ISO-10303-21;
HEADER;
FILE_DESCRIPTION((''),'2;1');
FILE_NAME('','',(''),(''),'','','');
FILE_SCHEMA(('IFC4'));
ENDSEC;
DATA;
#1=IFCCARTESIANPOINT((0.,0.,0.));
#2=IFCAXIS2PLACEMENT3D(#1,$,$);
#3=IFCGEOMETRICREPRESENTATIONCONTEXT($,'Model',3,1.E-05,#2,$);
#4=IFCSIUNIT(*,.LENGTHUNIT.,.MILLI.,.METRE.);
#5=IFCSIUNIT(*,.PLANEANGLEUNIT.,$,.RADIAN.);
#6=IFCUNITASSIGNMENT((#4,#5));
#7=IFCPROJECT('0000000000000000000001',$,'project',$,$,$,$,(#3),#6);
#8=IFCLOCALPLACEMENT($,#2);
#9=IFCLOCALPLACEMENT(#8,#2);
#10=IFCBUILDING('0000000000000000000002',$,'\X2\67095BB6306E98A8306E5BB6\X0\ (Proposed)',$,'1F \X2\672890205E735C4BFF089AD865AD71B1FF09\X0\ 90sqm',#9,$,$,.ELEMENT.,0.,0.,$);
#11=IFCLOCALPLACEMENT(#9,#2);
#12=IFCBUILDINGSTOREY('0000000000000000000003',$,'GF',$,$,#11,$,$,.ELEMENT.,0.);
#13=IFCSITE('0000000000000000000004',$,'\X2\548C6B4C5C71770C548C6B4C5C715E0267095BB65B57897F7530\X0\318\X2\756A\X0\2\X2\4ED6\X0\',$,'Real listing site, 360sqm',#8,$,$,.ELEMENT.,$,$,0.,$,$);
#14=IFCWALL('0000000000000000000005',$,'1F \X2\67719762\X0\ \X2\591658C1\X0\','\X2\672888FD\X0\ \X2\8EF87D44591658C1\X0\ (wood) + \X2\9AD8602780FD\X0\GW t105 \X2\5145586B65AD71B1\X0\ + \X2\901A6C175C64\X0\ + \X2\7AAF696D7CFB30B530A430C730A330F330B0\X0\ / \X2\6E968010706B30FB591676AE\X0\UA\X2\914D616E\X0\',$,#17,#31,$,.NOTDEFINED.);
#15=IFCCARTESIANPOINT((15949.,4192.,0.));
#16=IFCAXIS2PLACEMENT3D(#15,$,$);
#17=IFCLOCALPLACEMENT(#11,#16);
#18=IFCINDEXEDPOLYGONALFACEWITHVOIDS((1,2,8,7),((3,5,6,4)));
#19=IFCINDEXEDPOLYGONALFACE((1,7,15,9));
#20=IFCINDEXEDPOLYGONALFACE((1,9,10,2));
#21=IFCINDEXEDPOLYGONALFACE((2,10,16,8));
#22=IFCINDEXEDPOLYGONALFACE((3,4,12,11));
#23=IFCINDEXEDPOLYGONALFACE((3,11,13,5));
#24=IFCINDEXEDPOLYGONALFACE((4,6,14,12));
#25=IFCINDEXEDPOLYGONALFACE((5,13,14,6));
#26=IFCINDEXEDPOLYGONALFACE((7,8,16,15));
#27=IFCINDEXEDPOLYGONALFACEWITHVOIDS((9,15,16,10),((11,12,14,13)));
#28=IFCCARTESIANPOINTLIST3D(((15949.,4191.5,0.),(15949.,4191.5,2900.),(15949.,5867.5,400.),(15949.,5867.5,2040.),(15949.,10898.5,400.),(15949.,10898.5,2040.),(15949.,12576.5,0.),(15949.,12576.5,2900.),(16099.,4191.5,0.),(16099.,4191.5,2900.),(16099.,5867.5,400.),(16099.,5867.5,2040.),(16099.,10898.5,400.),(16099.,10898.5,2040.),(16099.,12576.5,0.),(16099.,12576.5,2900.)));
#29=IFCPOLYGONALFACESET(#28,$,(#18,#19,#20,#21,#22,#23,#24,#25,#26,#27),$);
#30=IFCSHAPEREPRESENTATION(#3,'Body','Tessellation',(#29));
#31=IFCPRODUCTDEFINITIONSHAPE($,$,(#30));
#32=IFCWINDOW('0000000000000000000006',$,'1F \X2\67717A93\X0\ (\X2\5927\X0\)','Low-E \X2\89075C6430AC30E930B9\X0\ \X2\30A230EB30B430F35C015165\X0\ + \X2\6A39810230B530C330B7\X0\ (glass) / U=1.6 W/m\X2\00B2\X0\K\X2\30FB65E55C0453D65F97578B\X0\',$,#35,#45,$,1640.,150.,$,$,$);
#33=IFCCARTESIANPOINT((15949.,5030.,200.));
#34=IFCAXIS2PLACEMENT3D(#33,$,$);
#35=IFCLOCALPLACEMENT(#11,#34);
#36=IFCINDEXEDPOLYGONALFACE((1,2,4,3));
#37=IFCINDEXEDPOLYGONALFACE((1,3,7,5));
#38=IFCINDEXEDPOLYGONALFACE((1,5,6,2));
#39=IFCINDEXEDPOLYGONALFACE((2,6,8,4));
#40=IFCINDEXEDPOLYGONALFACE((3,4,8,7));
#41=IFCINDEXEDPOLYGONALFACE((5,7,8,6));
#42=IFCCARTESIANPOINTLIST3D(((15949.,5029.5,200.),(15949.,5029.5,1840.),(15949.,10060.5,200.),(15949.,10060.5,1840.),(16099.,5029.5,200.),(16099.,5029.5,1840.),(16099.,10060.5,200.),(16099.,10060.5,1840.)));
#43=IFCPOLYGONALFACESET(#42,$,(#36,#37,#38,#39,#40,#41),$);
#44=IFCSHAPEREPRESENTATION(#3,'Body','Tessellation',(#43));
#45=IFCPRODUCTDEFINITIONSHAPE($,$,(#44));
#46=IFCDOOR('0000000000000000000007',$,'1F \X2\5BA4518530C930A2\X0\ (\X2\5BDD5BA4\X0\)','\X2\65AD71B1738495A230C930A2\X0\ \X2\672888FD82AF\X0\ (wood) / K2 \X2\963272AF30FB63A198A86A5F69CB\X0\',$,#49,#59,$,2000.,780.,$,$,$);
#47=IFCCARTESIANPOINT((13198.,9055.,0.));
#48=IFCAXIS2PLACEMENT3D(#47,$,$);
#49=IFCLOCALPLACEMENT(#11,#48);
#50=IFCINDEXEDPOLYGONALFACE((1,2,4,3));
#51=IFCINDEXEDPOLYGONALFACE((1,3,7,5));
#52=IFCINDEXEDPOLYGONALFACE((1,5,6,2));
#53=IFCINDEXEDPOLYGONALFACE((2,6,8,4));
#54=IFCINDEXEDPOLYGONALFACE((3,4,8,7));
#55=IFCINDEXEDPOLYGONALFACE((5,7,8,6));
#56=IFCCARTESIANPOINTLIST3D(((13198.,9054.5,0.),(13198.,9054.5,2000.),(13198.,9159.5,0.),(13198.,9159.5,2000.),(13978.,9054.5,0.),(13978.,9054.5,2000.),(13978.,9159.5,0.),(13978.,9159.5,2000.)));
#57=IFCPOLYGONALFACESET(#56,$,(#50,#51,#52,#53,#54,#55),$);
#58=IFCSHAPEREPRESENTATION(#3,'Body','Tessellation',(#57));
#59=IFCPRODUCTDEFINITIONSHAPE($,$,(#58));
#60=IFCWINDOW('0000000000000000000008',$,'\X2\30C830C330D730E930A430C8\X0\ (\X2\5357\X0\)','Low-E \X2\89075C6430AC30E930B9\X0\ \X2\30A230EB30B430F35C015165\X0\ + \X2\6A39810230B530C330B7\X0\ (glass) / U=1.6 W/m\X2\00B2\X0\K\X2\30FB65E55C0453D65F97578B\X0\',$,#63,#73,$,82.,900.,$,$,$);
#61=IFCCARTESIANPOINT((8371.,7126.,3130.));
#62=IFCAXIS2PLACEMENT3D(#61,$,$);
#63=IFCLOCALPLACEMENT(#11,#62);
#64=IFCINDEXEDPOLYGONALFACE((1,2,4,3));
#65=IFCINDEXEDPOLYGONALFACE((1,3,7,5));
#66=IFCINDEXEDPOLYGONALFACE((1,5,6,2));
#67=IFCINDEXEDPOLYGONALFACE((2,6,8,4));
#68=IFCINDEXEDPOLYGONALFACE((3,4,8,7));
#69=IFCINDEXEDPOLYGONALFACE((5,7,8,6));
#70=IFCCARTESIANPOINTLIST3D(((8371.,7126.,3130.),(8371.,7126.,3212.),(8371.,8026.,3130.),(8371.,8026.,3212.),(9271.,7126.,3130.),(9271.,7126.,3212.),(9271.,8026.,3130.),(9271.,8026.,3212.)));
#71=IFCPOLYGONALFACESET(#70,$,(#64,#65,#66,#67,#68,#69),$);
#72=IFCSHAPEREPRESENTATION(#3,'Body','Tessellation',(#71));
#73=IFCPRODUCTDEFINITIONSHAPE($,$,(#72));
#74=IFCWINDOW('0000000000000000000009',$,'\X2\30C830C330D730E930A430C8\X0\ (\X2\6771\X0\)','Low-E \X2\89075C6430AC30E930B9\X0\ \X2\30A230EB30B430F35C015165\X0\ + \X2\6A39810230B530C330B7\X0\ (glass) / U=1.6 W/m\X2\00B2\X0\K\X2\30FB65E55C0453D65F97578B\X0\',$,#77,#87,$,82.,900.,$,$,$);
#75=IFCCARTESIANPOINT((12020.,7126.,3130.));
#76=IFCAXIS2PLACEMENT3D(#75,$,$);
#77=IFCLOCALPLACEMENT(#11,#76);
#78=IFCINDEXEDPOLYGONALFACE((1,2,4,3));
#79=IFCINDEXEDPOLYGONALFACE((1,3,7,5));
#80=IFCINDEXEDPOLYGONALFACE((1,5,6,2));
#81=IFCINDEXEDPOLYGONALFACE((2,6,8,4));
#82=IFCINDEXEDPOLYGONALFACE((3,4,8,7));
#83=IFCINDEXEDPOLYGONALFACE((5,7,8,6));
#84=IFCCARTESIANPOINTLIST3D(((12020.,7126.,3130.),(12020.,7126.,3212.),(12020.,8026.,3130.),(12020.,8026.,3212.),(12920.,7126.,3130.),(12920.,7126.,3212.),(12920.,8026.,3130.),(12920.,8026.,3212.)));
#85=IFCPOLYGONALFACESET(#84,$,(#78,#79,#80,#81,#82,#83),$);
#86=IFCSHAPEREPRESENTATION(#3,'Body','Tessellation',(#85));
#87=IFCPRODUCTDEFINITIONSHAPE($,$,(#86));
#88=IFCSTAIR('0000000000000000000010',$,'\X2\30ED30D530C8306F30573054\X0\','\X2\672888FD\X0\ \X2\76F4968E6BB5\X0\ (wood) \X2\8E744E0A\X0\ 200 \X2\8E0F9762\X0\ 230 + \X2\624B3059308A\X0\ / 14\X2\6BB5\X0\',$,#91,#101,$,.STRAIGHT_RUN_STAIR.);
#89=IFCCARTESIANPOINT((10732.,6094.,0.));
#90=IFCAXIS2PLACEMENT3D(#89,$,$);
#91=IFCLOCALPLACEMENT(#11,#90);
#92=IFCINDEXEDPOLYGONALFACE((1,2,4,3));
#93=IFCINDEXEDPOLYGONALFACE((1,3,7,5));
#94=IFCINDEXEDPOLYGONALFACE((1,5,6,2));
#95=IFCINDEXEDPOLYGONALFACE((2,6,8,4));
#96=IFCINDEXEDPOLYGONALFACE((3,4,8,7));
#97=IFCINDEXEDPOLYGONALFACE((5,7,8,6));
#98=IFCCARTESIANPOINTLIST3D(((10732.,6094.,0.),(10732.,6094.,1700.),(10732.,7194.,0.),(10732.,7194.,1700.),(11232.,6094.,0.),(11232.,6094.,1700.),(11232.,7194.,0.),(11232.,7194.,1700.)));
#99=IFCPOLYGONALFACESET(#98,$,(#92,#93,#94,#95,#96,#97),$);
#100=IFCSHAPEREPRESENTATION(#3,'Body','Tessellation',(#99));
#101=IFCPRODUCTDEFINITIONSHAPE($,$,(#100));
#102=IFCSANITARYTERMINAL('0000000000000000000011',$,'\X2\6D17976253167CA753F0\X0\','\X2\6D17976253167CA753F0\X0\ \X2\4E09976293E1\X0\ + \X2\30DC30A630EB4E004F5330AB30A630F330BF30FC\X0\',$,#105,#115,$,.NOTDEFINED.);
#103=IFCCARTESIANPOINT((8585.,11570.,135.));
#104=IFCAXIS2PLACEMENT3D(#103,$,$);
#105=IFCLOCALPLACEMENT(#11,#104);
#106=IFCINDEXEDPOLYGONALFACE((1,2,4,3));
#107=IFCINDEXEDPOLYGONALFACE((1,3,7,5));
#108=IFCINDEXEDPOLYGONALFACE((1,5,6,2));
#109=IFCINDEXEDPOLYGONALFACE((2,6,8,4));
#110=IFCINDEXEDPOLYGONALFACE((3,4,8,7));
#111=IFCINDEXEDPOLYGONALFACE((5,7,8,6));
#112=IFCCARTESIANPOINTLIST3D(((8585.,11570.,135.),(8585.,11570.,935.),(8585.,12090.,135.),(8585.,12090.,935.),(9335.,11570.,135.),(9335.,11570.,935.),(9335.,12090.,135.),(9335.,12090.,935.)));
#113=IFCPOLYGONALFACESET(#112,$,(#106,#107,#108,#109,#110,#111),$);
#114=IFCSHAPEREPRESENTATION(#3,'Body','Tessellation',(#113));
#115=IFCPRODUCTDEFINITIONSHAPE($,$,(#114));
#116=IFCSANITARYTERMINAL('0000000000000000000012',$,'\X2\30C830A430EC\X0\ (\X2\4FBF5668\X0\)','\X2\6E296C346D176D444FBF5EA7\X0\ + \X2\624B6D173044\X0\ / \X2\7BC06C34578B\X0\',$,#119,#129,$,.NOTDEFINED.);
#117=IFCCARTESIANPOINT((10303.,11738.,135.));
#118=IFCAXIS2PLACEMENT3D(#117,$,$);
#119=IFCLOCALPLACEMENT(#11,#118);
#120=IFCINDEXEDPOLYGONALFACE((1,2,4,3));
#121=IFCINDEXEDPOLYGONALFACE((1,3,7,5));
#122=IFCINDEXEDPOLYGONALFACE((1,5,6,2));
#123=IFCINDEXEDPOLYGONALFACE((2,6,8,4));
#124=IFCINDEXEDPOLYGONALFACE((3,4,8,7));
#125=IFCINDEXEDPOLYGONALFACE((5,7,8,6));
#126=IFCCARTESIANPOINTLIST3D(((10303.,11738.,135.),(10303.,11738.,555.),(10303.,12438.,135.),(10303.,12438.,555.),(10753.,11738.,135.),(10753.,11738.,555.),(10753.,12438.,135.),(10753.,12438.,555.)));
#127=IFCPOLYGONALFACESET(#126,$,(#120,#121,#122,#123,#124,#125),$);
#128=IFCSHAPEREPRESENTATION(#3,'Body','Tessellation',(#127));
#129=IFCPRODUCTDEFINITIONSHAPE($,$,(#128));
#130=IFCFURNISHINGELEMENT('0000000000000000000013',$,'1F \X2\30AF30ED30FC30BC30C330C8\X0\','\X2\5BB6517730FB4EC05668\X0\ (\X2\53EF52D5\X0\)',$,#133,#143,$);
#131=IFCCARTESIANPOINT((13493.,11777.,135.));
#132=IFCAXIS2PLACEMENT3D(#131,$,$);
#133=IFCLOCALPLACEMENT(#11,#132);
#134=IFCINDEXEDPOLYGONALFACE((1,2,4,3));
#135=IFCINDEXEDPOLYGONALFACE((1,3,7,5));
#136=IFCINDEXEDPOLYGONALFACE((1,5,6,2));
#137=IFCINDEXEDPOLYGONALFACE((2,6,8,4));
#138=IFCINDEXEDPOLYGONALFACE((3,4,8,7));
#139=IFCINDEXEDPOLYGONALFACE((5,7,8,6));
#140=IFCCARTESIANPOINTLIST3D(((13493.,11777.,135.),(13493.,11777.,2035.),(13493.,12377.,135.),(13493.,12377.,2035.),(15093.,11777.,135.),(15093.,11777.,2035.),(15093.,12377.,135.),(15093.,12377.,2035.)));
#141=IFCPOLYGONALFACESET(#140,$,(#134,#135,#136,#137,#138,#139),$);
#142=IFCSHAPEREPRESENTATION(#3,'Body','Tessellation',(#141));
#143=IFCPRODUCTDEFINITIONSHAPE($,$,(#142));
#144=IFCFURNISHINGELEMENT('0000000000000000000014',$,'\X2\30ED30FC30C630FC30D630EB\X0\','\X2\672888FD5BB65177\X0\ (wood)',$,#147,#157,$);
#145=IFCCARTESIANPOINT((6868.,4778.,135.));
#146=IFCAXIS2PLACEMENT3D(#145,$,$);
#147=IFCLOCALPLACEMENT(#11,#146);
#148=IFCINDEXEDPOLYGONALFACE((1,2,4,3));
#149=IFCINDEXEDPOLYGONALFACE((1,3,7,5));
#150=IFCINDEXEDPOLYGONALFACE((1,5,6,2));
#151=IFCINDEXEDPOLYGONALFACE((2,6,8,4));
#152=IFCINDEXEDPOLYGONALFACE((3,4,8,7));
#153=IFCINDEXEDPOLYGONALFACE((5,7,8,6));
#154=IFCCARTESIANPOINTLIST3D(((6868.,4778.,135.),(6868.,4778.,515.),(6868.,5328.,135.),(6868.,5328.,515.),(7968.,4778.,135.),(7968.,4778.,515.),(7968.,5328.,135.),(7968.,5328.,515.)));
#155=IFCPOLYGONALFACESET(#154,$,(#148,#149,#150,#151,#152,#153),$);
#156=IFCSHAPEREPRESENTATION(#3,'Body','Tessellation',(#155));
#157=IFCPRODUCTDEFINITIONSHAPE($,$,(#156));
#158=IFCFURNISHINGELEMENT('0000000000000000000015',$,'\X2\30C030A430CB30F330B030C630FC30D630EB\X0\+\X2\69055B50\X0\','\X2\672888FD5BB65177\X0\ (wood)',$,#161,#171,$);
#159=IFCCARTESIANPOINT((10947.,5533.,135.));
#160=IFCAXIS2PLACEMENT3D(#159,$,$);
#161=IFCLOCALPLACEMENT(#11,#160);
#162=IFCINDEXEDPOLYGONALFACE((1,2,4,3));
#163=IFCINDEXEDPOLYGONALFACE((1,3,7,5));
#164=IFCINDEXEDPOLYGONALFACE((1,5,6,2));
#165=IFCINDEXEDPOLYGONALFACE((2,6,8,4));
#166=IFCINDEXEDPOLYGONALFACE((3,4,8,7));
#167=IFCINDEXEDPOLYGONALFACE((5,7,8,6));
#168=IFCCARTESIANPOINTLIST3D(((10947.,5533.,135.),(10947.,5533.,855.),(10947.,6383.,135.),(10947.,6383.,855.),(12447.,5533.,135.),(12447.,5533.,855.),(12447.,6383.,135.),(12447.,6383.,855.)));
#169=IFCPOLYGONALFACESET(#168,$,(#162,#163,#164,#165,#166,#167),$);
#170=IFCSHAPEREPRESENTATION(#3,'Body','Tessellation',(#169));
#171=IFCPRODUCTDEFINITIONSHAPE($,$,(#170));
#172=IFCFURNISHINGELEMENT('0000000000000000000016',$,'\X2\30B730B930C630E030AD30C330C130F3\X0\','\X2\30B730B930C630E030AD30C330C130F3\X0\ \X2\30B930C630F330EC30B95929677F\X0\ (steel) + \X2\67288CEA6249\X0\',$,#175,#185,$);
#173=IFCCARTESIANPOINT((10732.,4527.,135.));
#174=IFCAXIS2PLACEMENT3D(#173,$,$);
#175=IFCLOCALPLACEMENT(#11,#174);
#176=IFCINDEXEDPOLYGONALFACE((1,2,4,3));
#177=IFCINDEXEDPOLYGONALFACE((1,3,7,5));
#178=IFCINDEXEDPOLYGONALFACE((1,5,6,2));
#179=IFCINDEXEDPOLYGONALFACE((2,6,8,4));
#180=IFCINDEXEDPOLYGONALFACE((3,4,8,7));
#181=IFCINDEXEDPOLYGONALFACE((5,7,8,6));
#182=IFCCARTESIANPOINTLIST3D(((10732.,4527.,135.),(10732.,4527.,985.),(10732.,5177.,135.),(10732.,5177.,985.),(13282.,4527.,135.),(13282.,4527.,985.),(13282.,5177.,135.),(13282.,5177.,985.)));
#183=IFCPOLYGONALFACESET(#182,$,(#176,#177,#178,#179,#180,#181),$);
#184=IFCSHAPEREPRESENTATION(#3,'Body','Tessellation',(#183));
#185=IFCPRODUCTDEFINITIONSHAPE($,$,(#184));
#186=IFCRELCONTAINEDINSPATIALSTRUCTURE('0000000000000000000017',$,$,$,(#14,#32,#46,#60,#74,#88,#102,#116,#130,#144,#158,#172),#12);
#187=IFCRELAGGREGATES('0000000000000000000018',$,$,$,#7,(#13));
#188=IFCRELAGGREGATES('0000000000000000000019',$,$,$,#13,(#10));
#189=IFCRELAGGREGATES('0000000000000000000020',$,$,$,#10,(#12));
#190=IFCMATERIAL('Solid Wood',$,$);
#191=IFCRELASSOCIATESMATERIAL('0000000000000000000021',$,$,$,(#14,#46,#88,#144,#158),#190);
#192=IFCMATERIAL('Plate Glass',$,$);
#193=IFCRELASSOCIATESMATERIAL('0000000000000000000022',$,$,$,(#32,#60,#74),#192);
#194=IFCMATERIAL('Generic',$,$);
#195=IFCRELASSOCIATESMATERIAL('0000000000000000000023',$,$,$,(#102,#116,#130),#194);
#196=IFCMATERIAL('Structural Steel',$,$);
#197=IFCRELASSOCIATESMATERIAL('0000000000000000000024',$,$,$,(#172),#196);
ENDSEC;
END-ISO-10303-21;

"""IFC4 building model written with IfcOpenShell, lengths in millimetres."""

from ifc_helpers import new_model, si_unit, frame, frame_2d, origin, place, context, project, spatial, rectangle, extrude, material, element, fill, save


model = new_model("IFC4")

# Units and contexts
model_context = context("Model", 3, precision=1e-05, world=origin())
ifc_project = project(units=[si_unit("LENGTHUNIT", "METRE", prefix="MILLI"), si_unit("PLANEANGLEUNIT", "RADIAN")], contexts=[model_context])

# Site, building, storey
site_placement = place(None, origin())
site = spatial("IfcSite", under=ifc_project, at=site_placement, Name="和歌山県和歌山市有家字西田318番2他", ObjectType="Real listing site, 360sqm", CompositionType="ELEMENT", RefElevation=0.0)
building_placement = place(site_placement, origin())
building = spatial("IfcBuilding", under=site, at=building_placement, Name="有家の風の家 (Proposed)", ObjectType="1F 木造平屋（高断熱） 90sqm", CompositionType="ELEMENT", ElevationOfRefHeight=0.0, ElevationOfTerrain=0.0)
storey_placement = place(building_placement, origin())
storey = spatial("IfcBuildingStorey", under=building, at=storey_placement, Name="GF", CompositionType="ELEMENT", Elevation=0.0)

# Wall, opening, window
ifc_material_1 = material(Name="Solid Wood")
wall_1_placement = place(storey_placement, frame((15949.0, 4192.0, 0.0)))
wall_1 = element("IfcWall", 1, at=wall_1_placement, inside=storey, material=ifc_material_1, Name="1F 東面 外壁", Description="木製 軸組外壁 (wood) + 高性能GW t105 充填断熱 + 通気層 + 窯業系サイディング / 準耐火・外皮UA配慮", PredefinedType="NOTDEFINED", context=model_context, shape_type="SweptSolid", body=[
    extrude(rectangle(XDim=150.0, YDim=8385.0, at=frame_2d((75.0, 4192.0))), frame((15949.0, 4192.0, 0.0)), (0.0, 0.0, 1.0), 2900.0),
])
opening_placement = place(storey_placement, frame((15949.0, 5030.0, 200.0)))
opening = element("IfcOpeningElement", 2, at=opening_placement, cuts=wall_1, PredefinedType="NOTDEFINED", context=model_context, shape_type="SweptSolid", body=[
    extrude(rectangle(XDim=150.0, YDim=5031.0, at=frame_2d((75.0, 2515.0))), frame((15949.0, 5030.0, 200.0)), (0.0, 0.0, 1.0), 1640.0),
])
ifc_material_2 = material(Name="Plate Glass")
window_1_placement = place(storey_placement, frame((15949.0, 5030.0, 200.0)))
window_1 = element("IfcWindow", 3, at=window_1_placement, inside=storey, material=ifc_material_2, Name="1F 東窓 (大)", Description="Low-E 複層ガラス アルゴン封入 + 樹脂サッシ (glass) / U=1.6 W/m²K・日射取得型", OverallHeight=1640.0, OverallWidth=150.0, context=model_context, shape_type="SweptSolid", body=[
    extrude(rectangle(XDim=150.0, YDim=5031.0, at=frame_2d((75.0, 2515.0))), frame((15949.0, 5030.0, 200.0)), (0.0, 0.0, 1.0), 1640.0),
])
fill(opening, window_1)

# Door
door_placement = place(storey_placement, frame((13198.0, 9055.0, 0.0)))
element("IfcDoor", 4, at=door_placement, inside=storey, material=ifc_material_1, Name="1F 室内ドア (寝室)", Description="断熱玄関ドア 木製芯 (wood) / K2 防犯・採風機構", OverallHeight=2000.0, OverallWidth=780.0, context=model_context, shape_type="SweptSolid", body=[
    extrude(rectangle(XDim=780.0, YDim=105.0, at=frame_2d((390.0, 52.0))), frame((13198.0, 9055.0, 0.0)), (0.0, 0.0, 1.0), 2000.0),
])

# Windows
window_2_placement = place(storey_placement, frame((8371.0, 7126.0, 3130.0)))
element("IfcWindow", 5, at=window_2_placement, inside=storey, material=ifc_material_2, Name="トップライト (南)", Description="Low-E 複層ガラス アルゴン封入 + 樹脂サッシ (glass) / U=1.6 W/m²K・日射取得型", OverallHeight=82.0, OverallWidth=900.0, context=model_context, shape_type="SweptSolid", body=[
    extrude(rectangle(XDim=900.0, YDim=900.0, at=frame_2d((450.0, 450.0))), frame((8371.0, 7126.0, 3130.0)), (0.0, 0.0, 1.0), 82.0),
])
window_3_placement = place(storey_placement, frame((12020.0, 7126.0, 3130.0)))
element("IfcWindow", 6, at=window_3_placement, inside=storey, material=ifc_material_2, Name="トップライト (東)", Description="Low-E 複層ガラス アルゴン封入 + 樹脂サッシ (glass) / U=1.6 W/m²K・日射取得型", OverallHeight=82.0, OverallWidth=900.0, context=model_context, shape_type="SweptSolid", body=[
    extrude(rectangle(XDim=900.0, YDim=900.0, at=frame_2d((450.0, 450.0))), frame((12020.0, 7126.0, 3130.0)), (0.0, 0.0, 1.0), 82.0),
])

# Stair
stair_placement = place(storey_placement, frame((10732.0, 6094.0, 0.0)))
element("IfcStair", 7, at=stair_placement, inside=storey, material=ifc_material_1, Name="ロフトはしご", Description="木製 直階段 (wood) 蹴上 200 踏面 230 + 手すり / 14段", PredefinedType="STRAIGHT_RUN_STAIR", context=model_context, shape_type="SweptSolid", body=[
    extrude(rectangle(XDim=500.0, YDim=1100.0, at=frame_2d((250.0, 550.0))), frame((10732.0, 6094.0, 0.0)), (0.0, 0.0, 1.0), 1700.0),
])

# Sanitary terminals
ifc_material_3 = material(Name="Generic")
sanitary_terminal_1_placement = place(storey_placement, frame((8585.0, 11570.0, 135.0)))
element("IfcSanitaryTerminal", 8, at=sanitary_terminal_1_placement, inside=storey, material=ifc_material_3, Name="洗面化粧台", Description="洗面化粧台 三面鏡 + ボウル一体カウンター", PredefinedType="NOTDEFINED", context=model_context, shape_type="SweptSolid", body=[
    extrude(rectangle(XDim=750.0, YDim=520.0, at=frame_2d((375.0, 260.0))), frame((8585.0, 11570.0, 135.0)), (0.0, 0.0, 1.0), 800.0),
])
sanitary_terminal_2_placement = place(storey_placement, frame((10303.0, 11738.0, 135.0)))
element("IfcSanitaryTerminal", 9, at=sanitary_terminal_2_placement, inside=storey, material=ifc_material_3, Name="トイレ (便器)", Description="温水洗浄便座 + 手洗い / 節水型", PredefinedType="NOTDEFINED", context=model_context, shape_type="SweptSolid", body=[
    extrude(rectangle(XDim=450.0, YDim=700.0, at=frame_2d((225.0, 350.0))), frame((10303.0, 11738.0, 135.0)), (0.0, 0.0, 1.0), 420.0),
])

# Furnishing elements
furnishing_1_placement = place(storey_placement, frame((13493.0, 11777.0, 135.0)))
element("IfcFurnishingElement", 10, at=furnishing_1_placement, inside=storey, material=ifc_material_3, Name="1F クローゼット", Description="家具・什器 (可動)", context=model_context, shape_type="SweptSolid", body=[
    extrude(rectangle(XDim=1600.0, YDim=600.0, at=frame_2d((800.0, 300.0))), frame((13493.0, 11777.0, 135.0)), (0.0, 0.0, 1.0), 1900.0),
])
furnishing_2_placement = place(storey_placement, frame((6868.0, 4778.0, 135.0)))
element("IfcFurnishingElement", 11, at=furnishing_2_placement, inside=storey, material=ifc_material_1, Name="ローテーブル", Description="木製家具 (wood)", context=model_context, shape_type="SweptSolid", body=[
    extrude(rectangle(XDim=1100.0, YDim=550.0, at=frame_2d((550.0, 275.0))), frame((6868.0, 4778.0, 135.0)), (0.0, 0.0, 1.0), 380.0),
])
furnishing_3_placement = place(storey_placement, frame((10947.0, 5533.0, 135.0)))
element("IfcFurnishingElement", 12, at=furnishing_3_placement, inside=storey, material=ifc_material_1, Name="ダイニングテーブル+椅子", Description="木製家具 (wood)", context=model_context, shape_type="SweptSolid", body=[
    extrude(rectangle(XDim=1500.0, YDim=850.0, at=frame_2d((750.0, 425.0))), frame((10947.0, 5533.0, 135.0)), (0.0, 0.0, 1.0), 720.0),
])
ifc_material_4 = material(Name="Structural Steel")
furnishing_4_placement = place(storey_placement, frame((10732.0, 4527.0, 135.0)))
element("IfcFurnishingElement", 13, at=furnishing_4_placement, inside=storey, material=ifc_material_4, Name="システムキッチン", Description="システムキッチン ステンレス天板 (steel) + 木質扉", context=model_context, shape_type="SweptSolid", body=[
    extrude(rectangle(XDim=2550.0, YDim=650.0, at=frame_2d((1275.0, 325.0))), frame((10732.0, 4527.0, 135.0)), (0.0, 0.0, 1.0), 850.0),
])

save(model, "model.ifc")
